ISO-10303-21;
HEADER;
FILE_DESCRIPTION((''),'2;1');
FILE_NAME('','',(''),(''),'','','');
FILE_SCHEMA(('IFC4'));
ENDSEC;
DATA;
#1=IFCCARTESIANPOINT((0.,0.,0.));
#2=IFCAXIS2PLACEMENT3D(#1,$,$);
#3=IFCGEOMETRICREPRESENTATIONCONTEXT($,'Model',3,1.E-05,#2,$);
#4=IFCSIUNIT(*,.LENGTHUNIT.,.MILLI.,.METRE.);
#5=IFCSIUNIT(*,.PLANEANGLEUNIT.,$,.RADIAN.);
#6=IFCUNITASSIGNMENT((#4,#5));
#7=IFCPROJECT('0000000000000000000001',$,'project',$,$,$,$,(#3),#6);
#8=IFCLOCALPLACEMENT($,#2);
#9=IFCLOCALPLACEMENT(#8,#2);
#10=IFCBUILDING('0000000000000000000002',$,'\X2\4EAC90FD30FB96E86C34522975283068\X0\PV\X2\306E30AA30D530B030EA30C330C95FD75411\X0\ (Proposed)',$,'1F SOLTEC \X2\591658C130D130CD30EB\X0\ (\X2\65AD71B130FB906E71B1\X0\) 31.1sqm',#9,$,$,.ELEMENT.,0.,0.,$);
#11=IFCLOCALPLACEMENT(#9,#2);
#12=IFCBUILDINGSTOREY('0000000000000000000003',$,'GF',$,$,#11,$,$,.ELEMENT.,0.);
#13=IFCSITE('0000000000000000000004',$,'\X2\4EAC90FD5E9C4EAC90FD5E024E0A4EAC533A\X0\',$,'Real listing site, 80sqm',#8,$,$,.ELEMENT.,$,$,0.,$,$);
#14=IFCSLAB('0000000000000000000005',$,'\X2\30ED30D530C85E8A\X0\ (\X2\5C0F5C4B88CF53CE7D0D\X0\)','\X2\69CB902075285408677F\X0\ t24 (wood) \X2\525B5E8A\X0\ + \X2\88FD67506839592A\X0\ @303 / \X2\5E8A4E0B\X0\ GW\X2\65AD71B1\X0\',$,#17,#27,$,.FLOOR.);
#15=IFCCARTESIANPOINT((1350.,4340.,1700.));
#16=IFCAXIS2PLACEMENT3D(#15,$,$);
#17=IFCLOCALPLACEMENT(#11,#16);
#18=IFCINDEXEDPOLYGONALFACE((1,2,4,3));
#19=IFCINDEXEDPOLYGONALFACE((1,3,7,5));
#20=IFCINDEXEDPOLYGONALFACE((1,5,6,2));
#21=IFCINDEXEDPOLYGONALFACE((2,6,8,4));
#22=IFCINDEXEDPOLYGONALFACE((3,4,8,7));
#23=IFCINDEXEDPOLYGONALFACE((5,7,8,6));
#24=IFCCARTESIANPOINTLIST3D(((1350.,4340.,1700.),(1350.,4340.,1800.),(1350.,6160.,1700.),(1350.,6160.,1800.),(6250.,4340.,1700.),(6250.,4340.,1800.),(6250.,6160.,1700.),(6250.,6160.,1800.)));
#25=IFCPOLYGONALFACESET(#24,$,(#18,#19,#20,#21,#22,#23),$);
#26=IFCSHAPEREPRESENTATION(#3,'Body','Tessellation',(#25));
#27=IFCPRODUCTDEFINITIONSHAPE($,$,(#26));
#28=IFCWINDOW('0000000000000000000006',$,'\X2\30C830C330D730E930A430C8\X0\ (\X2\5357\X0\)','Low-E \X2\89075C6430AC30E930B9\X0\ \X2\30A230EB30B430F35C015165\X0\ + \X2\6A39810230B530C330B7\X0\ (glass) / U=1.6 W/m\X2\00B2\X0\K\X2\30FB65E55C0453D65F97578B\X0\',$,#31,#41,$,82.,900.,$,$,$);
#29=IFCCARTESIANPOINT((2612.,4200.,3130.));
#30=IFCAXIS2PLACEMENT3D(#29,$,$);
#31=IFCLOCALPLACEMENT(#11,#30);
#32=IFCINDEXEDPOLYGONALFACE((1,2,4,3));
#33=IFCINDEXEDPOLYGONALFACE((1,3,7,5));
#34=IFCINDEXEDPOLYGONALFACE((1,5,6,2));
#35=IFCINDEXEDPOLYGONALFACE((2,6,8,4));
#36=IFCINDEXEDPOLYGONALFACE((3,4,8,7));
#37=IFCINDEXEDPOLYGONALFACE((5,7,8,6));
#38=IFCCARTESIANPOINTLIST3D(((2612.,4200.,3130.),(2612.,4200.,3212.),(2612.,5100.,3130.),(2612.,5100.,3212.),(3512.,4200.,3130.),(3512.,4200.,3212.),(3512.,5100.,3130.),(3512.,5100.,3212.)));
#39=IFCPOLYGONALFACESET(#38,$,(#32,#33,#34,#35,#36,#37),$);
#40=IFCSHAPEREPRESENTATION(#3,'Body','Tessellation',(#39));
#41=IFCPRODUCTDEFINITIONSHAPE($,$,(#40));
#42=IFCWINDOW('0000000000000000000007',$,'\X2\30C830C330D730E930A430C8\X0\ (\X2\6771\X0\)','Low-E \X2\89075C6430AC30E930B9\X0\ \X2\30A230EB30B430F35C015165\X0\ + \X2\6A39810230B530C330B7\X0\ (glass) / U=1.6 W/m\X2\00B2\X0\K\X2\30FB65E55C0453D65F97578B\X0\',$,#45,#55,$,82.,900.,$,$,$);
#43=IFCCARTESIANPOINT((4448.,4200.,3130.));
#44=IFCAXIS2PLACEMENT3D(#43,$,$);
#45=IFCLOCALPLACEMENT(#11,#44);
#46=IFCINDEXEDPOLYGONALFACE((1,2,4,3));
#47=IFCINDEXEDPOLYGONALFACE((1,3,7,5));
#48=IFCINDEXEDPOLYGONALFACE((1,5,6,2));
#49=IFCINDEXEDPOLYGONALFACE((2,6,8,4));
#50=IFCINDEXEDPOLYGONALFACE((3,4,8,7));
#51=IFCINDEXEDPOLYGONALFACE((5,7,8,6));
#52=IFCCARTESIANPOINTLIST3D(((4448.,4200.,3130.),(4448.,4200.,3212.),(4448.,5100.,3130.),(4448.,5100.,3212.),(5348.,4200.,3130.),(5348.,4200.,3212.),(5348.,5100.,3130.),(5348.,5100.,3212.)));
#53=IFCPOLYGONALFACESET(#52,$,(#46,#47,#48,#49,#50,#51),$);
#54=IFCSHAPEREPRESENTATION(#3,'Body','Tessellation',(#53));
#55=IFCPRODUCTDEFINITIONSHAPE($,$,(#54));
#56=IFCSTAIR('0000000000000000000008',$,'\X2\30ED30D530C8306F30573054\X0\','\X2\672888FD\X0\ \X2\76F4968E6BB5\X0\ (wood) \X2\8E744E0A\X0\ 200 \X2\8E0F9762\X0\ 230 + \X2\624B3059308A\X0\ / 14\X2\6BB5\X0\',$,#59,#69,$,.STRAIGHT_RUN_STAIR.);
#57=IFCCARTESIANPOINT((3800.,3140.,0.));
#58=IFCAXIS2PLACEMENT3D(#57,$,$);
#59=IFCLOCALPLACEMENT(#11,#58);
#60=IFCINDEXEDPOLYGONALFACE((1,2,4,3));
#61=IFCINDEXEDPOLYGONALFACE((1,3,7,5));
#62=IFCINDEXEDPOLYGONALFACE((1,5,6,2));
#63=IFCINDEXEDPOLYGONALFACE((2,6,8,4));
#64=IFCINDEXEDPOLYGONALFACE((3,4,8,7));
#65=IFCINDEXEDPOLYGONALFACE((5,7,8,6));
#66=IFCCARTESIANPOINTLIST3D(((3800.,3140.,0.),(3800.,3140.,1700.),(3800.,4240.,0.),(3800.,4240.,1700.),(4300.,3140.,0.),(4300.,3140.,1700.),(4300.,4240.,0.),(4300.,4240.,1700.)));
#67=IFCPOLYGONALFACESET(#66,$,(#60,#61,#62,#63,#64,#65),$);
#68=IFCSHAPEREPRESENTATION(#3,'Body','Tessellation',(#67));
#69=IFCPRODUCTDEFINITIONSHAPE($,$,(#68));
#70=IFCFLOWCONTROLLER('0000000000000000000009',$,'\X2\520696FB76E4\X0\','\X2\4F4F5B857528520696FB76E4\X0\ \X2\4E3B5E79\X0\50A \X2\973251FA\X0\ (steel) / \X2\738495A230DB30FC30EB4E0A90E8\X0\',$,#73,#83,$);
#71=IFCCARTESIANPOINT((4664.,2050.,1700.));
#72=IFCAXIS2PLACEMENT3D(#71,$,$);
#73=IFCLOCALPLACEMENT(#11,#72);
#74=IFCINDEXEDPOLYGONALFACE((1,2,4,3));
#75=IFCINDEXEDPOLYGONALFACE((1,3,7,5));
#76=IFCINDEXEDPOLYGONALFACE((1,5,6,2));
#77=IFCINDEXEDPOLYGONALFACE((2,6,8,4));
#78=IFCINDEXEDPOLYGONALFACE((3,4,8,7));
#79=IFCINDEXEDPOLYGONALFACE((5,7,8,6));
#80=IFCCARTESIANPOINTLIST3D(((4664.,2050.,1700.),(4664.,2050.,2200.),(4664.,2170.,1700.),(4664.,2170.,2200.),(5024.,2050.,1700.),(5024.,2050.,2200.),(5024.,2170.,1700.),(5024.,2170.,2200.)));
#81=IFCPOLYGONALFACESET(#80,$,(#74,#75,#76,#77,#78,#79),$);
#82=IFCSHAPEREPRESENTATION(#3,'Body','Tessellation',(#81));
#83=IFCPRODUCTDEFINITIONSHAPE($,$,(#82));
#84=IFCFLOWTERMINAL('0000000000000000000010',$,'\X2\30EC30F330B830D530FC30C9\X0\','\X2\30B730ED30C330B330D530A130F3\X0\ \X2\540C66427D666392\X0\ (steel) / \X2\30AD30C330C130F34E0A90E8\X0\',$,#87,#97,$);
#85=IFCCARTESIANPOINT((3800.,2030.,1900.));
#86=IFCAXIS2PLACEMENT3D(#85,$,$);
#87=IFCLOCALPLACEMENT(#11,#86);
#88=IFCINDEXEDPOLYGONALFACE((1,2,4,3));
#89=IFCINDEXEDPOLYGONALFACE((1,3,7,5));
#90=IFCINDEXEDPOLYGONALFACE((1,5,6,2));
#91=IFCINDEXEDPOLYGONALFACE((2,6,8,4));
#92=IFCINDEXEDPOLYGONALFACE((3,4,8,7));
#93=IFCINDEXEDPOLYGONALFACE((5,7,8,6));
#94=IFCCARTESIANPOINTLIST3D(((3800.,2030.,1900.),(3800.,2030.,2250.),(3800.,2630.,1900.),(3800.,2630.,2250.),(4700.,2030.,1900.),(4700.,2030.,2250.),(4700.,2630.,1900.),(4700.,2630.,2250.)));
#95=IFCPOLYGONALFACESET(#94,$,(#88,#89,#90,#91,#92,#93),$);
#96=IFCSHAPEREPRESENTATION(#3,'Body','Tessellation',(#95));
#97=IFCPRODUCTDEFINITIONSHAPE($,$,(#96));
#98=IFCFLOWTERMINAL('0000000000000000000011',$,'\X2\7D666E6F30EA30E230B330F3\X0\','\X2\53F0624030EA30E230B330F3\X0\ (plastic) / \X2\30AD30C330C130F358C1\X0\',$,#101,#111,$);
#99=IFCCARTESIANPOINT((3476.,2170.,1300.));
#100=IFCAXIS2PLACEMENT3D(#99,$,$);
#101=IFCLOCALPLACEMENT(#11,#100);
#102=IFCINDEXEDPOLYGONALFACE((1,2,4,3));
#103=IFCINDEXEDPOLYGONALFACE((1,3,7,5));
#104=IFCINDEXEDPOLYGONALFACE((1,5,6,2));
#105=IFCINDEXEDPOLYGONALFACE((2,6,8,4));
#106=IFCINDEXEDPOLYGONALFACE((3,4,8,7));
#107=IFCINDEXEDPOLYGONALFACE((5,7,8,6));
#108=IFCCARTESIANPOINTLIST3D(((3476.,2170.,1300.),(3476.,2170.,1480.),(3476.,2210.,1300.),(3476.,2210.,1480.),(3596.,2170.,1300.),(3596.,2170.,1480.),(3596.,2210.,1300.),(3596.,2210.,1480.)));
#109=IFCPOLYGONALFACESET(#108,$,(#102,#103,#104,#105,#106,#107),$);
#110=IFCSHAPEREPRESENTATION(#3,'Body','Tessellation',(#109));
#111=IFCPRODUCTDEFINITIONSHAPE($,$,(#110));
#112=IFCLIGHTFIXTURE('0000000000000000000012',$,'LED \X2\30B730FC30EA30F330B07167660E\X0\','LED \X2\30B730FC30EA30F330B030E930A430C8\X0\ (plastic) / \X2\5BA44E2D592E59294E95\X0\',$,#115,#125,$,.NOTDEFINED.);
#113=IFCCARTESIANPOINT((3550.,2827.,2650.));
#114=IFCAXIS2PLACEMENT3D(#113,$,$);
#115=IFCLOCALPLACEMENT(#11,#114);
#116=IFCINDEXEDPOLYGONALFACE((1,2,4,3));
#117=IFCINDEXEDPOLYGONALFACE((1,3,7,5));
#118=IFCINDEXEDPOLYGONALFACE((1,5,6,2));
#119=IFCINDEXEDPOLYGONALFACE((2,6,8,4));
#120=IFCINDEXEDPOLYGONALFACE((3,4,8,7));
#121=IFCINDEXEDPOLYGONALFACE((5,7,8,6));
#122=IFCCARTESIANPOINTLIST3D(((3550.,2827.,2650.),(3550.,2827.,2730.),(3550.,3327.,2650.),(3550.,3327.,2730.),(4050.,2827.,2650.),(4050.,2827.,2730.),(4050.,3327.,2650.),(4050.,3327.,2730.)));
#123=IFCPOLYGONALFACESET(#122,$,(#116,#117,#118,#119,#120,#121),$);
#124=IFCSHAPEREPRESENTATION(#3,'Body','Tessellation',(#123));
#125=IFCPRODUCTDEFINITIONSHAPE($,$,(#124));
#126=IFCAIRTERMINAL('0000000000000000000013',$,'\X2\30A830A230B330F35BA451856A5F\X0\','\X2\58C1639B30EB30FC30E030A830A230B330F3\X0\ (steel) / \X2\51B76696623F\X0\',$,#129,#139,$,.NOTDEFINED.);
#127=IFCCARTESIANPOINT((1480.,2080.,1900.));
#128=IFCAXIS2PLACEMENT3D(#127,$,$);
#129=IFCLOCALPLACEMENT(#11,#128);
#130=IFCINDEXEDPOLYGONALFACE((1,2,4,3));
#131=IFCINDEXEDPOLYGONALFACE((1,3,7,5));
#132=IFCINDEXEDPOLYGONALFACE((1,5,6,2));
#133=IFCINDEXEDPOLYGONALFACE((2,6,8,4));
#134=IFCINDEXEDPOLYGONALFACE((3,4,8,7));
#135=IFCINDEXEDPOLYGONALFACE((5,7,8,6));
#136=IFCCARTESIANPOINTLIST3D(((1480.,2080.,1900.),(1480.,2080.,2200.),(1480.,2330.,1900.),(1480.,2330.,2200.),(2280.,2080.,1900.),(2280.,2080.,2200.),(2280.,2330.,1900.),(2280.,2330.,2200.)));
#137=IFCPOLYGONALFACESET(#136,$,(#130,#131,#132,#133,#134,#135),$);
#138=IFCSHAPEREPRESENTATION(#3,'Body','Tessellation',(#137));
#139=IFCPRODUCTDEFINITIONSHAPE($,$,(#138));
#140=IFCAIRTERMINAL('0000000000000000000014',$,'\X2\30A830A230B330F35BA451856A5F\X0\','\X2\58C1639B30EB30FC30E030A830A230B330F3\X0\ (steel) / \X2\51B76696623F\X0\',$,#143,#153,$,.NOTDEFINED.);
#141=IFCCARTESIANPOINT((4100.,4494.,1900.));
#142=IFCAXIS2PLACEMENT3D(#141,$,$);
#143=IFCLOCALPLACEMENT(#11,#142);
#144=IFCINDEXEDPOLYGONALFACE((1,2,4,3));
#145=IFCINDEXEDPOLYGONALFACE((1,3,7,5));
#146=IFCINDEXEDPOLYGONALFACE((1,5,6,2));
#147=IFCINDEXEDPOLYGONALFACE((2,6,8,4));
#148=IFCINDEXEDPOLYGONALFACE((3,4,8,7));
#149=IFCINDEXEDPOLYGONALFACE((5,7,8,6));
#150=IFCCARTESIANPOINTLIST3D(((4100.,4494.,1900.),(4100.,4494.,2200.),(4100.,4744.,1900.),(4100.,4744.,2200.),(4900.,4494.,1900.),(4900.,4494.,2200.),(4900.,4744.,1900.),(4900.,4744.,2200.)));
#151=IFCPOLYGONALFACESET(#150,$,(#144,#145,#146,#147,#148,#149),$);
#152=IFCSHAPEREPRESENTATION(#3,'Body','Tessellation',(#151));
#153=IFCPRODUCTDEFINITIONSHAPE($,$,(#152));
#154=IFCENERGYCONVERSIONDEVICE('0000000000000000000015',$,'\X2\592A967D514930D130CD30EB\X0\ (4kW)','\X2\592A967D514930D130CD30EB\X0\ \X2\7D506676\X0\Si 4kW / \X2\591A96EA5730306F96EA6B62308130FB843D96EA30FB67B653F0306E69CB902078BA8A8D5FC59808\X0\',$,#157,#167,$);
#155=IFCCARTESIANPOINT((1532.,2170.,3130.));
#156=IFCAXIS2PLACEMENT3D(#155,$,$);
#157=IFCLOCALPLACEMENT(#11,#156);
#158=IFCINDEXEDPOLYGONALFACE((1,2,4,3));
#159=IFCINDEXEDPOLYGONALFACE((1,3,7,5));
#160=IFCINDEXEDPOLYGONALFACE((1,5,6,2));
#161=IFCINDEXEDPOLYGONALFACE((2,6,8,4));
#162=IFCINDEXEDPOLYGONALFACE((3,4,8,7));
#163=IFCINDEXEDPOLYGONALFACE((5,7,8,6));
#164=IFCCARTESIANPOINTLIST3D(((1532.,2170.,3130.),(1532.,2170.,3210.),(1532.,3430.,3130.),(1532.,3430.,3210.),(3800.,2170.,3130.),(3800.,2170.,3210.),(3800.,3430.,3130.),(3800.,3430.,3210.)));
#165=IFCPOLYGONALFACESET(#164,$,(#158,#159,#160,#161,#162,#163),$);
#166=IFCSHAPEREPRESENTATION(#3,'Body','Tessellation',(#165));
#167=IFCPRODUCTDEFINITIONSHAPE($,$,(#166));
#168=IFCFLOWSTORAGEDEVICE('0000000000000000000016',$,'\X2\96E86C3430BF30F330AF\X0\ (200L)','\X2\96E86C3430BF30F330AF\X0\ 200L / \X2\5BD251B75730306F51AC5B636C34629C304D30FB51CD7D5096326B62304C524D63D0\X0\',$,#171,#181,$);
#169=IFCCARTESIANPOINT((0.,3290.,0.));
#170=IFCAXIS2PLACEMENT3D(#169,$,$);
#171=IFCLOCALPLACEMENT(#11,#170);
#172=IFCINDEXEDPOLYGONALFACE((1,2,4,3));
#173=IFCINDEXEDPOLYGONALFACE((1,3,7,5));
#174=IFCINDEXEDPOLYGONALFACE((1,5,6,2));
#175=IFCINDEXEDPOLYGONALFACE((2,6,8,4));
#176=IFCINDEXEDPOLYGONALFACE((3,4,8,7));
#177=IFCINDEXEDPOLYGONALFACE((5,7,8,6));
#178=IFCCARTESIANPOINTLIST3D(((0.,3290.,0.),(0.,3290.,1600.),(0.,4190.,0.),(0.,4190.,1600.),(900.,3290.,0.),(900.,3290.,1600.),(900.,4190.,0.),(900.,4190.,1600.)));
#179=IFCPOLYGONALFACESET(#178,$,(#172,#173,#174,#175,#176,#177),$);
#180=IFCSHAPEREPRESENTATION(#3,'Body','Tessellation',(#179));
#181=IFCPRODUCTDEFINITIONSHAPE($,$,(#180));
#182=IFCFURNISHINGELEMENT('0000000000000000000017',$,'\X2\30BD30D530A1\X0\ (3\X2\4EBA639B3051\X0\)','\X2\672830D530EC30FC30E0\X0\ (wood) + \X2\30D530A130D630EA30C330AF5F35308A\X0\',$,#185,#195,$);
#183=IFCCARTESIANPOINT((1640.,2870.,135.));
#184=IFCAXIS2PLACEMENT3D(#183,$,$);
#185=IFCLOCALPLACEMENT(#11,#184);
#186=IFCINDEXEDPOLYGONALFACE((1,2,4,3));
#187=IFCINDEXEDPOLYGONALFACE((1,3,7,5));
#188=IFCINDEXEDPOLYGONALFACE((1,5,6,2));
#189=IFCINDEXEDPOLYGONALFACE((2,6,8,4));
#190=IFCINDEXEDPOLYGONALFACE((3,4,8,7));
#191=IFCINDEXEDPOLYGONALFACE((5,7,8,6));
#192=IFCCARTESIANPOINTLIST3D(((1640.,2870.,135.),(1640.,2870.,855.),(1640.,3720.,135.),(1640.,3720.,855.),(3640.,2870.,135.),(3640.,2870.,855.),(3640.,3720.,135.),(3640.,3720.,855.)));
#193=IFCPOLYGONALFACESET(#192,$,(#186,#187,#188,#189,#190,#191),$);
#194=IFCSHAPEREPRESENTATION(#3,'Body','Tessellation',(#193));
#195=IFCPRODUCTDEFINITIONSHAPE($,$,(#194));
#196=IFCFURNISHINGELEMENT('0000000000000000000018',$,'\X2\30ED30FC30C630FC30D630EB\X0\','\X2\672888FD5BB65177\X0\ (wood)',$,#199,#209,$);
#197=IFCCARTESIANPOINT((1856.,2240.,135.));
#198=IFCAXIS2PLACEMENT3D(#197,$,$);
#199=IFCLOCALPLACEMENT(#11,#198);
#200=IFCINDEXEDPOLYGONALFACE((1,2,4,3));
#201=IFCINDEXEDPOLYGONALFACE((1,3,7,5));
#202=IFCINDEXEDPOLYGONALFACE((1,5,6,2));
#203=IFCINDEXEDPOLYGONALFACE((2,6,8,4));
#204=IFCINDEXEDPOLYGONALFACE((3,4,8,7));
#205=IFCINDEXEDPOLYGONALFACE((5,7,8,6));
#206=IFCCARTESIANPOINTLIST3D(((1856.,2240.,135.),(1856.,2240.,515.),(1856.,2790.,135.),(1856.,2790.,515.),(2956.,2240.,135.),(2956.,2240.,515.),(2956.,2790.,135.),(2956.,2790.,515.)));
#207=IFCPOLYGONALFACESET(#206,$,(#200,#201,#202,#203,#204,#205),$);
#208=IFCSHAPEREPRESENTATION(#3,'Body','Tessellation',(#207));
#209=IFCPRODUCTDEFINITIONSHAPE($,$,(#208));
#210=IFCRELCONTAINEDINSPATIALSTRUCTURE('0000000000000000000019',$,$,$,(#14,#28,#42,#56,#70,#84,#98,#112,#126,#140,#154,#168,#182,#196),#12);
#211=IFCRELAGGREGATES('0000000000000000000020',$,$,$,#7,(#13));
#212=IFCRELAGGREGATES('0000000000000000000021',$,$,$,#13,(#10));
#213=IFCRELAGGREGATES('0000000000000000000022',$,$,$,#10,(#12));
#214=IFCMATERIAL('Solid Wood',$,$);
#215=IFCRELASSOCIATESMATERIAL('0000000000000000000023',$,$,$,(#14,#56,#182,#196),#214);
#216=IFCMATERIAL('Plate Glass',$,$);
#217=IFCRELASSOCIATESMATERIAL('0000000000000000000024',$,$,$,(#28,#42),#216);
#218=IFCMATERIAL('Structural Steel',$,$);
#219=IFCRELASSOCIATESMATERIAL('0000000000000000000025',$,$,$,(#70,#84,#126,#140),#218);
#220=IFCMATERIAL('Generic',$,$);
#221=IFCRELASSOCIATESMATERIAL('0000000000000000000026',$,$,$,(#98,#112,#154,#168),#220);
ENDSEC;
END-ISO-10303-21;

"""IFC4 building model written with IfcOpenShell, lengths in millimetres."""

from ifc_helpers import new_model, si_unit, frame, frame_2d, origin, place, context, project, spatial, rectangle, extrude, material, element, save


model = new_model("IFC4")

# Units and contexts
model_context = context("Model", 3, precision=1e-05, world=origin())
ifc_project = project(units=[si_unit("LENGTHUNIT", "METRE", prefix="MILLI"), si_unit("PLANEANGLEUNIT", "RADIAN")], contexts=[model_context])

# Site, building, storey
site_placement = place(None, origin())
site = spatial("IfcSite", under=ifc_project, at=site_placement, Name="京都府京都市上京区", ObjectType="Real listing site, 80sqm", CompositionType="ELEMENT", RefElevation=0.0)
building_placement = place(site_placement, origin())
building = spatial("IfcBuilding", under=site, at=building_placement, Name="京都・雨水利用とPVのオフグリッド志向 (Proposed)", ObjectType="1F SOLTEC 外壁パネル (断熱・遮熱) 31.1sqm", CompositionType="ELEMENT", ElevationOfRefHeight=0.0, ElevationOfTerrain=0.0)
storey_placement = place(building_placement, origin())
storey = spatial("IfcBuildingStorey", under=building, at=storey_placement, Name="GF", CompositionType="ELEMENT", Elevation=0.0)

# Shared definitions
ifc_material_1 = material(Name="Solid Wood")

# Slab
slab_placement = place(storey_placement, frame((1350.0, 4340.0, 1700.0)))
element("IfcSlab", 1, at=slab_placement, inside=storey, material=ifc_material_1, Name="ロフト床 (小屋裏収納)", Description="構造用合板 t24 (wood) 剛床 + 製材根太 @303 / 床下 GW断熱", PredefinedType="FLOOR", context=model_context, shape_type="SweptSolid", body=[
    extrude(rectangle(XDim=4900.0, YDim=1820.0, at=frame_2d((2450.0, 910.0))), frame((1350.0, 4340.0, 1700.0)), (0.0, 0.0, 1.0), 100.0),
])

# Windows
ifc_material_2 = material(Name="Plate Glass")
window_1_placement = place(storey_placement, frame((2612.0, 4200.0, 3130.0)))
element("IfcWindow", 2, at=window_1_placement, inside=storey, material=ifc_material_2, Name="トップライト (南)", Description="Low-E 複層ガラス アルゴン封入 + 樹脂サッシ (glass) / U=1.6 W/m²K・日射取得型", OverallHeight=82.0, OverallWidth=900.0, context=model_context, shape_type="SweptSolid", body=[
    extrude(rectangle(XDim=900.0, YDim=900.0, at=frame_2d((450.0, 450.0))), frame((2612.0, 4200.0, 3130.0)), (0.0, 0.0, 1.0), 82.0),
])
window_2_placement = place(storey_placement, frame((4448.0, 4200.0, 3130.0)))
element("IfcWindow", 3, at=window_2_placement, inside=storey, material=ifc_material_2, Name="トップライト (東)", Description="Low-E 複層ガラス アルゴン封入 + 樹脂サッシ (glass) / U=1.6 W/m²K・日射取得型", OverallHeight=82.0, OverallWidth=900.0, context=model_context, shape_type="SweptSolid", body=[
    extrude(rectangle(XDim=900.0, YDim=900.0, at=frame_2d((450.0, 450.0))), frame((4448.0, 4200.0, 3130.0)), (0.0, 0.0, 1.0), 82.0),
])

# Stair
stair_placement = place(storey_placement, frame((3800.0, 3140.0, 0.0)))
element("IfcStair", 4, at=stair_placement, inside=storey, material=ifc_material_1, Name="ロフトはしご", Description="木製 直階段 (wood) 蹴上 200 踏面 230 + 手すり / 14段", PredefinedType="STRAIGHT_RUN_STAIR", context=model_context, shape_type="SweptSolid", body=[
    extrude(rectangle(XDim=500.0, YDim=1100.0, at=frame_2d((250.0, 550.0))), frame((3800.0, 3140.0, 0.0)), (0.0, 0.0, 1.0), 1700.0),
])

# Flow controller
ifc_material_3 = material(Name="Structural Steel")
flow_controller_placement = place(storey_placement, frame((4664.0, 2050.0, 1700.0)))
element("IfcFlowController", 5, at=flow_controller_placement, inside=storey, material=ifc_material_3, Name="分電盤", Description="住宅用分電盤 主幹50A 露出 (steel) / 玄関ホール上部", context=model_context, shape_type="SweptSolid", body=[
    extrude(rectangle(XDim=360.0, YDim=120.0, at=frame_2d((180.0, 60.0))), frame((4664.0, 2050.0, 1700.0)), (0.0, 0.0, 1.0), 500.0),
])

# Flow terminals
flow_terminal_1_placement = place(storey_placement, frame((3800.0, 2030.0, 1900.0)))
element("IfcFlowTerminal", 6, at=flow_terminal_1_placement, inside=storey, material=ifc_material_3, Name="レンジフード", Description="シロッコファン 同時給排 (steel) / キッチン上部", context=model_context, shape_type="SweptSolid", body=[
    extrude(rectangle(XDim=900.0, YDim=600.0, at=frame_2d((450.0, 300.0))), frame((3800.0, 2030.0, 1900.0)), (0.0, 0.0, 1.0), 350.0),
])
ifc_material_4 = material(Name="Generic")
flow_terminal_2_placement = place(storey_placement, frame((3476.0, 2170.0, 1300.0)))
element("IfcFlowTerminal", 7, at=flow_terminal_2_placement, inside=storey, material=ifc_material_4, Name="給湯リモコン", Description="台所リモコン (plastic) / キッチン壁", context=model_context, shape_type="SweptSolid", body=[
    extrude(rectangle(XDim=120.0, YDim=40.0, at=frame_2d((60.0, 20.0))), frame((3476.0, 2170.0, 1300.0)), (0.0, 0.0, 1.0), 180.0),
])

# Light fixture
light_fixture_placement = place(storey_placement, frame((3550.0, 2827.0, 2650.0)))
element("IfcLightFixture", 8, at=light_fixture_placement, inside=storey, material=ifc_material_4, Name="LED シーリング照明", Description="LED シーリングライト (plastic) / 室中央天井", PredefinedType="NOTDEFINED", context=model_context, shape_type="SweptSolid", body=[
    extrude(rectangle(XDim=500.0, YDim=500.0, at=frame_2d((250.0, 250.0))), frame((3550.0, 2827.0, 2650.0)), (0.0, 0.0, 1.0), 80.0),
])

# Air terminals
air_terminal_1_placement = place(storey_placement, frame((1480.0, 2080.0, 1900.0)))
element("IfcAirTerminal", 9, at=air_terminal_1_placement, inside=storey, material=ifc_material_3, Name="エアコン室内機", Description="壁掛ルームエアコン (steel) / 冷暖房", PredefinedType="NOTDEFINED", context=model_context, shape_type="SweptSolid", body=[
    extrude(rectangle(XDim=800.0, YDim=250.0, at=frame_2d((400.0, 125.0))), frame((1480.0, 2080.0, 1900.0)), (0.0, 0.0, 1.0), 300.0),
])
air_terminal_2_placement = place(storey_placement, frame((4100.0, 4494.0, 1900.0)))
element("IfcAirTerminal", 10, at=air_terminal_2_placement, inside=storey, material=ifc_material_3, Name="エアコン室内機", Description="壁掛ルームエアコン (steel) / 冷暖房", PredefinedType="NOTDEFINED", context=model_context, shape_type="SweptSolid", body=[
    extrude(rectangle(XDim=800.0, YDim=250.0, at=frame_2d((400.0, 125.0))), frame((4100.0, 4494.0, 1900.0)), (0.0, 0.0, 1.0), 300.0),
])

# Energy conversion device
energy_conversion_device_placement = place(storey_placement, frame((1532.0, 2170.0, 3130.0)))
element("IfcEnergyConversionDevice", 11, at=energy_conversion_device_placement, inside=storey, material=ifc_material_4, Name="太陽光パネル (4kW)", Description="太陽光パネル 結晶Si 4kW / 多雪地は雪止め・落雪・架台の構造確認必須", context=model_context, shape_type="SweptSolid", body=[
    extrude(rectangle(XDim=2268.0, YDim=1260.0, at=frame_2d((1134.0, 630.0))), frame((1532.0, 2170.0, 3130.0)), (0.0, 0.0, 1.0), 80.0),
])

# Flow storage device
flow_storage_device_placement = place(storey_placement, frame((0.0, 3290.0, 0.0)))
element("IfcFlowStorageDevice", 12, at=flow_storage_device_placement, inside=storey, material=ifc_material_4, Name="雨水タンク (200L)", Description="雨水タンク 200L / 寒冷地は冬季水抜き・凍結防止が前提", context=model_context, shape_type="SweptSolid", body=[
    extrude(rectangle(XDim=900.0, YDim=900.0, at=frame_2d((450.0, 450.0))), frame((0.0, 3290.0, 0.0)), (0.0, 0.0, 1.0), 1600.0),
])

# Furnishing elements
furnishing_1_placement = place(storey_placement, frame((1640.0, 2870.0, 135.0)))
element("IfcFurnishingElement", 13, at=furnishing_1_placement, inside=storey, material=ifc_material_1, Name="ソファ (3人掛け)", Description="木フレーム (wood) + ファブリック張り", context=model_context, shape_type="SweptSolid", body=[
    extrude(rectangle(XDim=2000.0, YDim=850.0, at=frame_2d((1000.0, 425.0))), frame((1640.0, 2870.0, 135.0)), (0.0, 0.0, 1.0), 720.0),
])
furnishing_2_placement = place(storey_placement, frame((1856.0, 2240.0, 135.0)))
element("IfcFurnishingElement", 14, at=furnishing_2_placement, inside=storey, material=ifc_material_1, Name="ローテーブル", Description="木製家具 (wood)", context=model_context, shape_type="SweptSolid", body=[
    extrude(rectangle(XDim=1100.0, YDim=550.0, at=frame_2d((550.0, 275.0))), frame((1856.0, 2240.0, 135.0)), (0.0, 0.0, 1.0), 380.0),
])

save(model, "model.ifc")
